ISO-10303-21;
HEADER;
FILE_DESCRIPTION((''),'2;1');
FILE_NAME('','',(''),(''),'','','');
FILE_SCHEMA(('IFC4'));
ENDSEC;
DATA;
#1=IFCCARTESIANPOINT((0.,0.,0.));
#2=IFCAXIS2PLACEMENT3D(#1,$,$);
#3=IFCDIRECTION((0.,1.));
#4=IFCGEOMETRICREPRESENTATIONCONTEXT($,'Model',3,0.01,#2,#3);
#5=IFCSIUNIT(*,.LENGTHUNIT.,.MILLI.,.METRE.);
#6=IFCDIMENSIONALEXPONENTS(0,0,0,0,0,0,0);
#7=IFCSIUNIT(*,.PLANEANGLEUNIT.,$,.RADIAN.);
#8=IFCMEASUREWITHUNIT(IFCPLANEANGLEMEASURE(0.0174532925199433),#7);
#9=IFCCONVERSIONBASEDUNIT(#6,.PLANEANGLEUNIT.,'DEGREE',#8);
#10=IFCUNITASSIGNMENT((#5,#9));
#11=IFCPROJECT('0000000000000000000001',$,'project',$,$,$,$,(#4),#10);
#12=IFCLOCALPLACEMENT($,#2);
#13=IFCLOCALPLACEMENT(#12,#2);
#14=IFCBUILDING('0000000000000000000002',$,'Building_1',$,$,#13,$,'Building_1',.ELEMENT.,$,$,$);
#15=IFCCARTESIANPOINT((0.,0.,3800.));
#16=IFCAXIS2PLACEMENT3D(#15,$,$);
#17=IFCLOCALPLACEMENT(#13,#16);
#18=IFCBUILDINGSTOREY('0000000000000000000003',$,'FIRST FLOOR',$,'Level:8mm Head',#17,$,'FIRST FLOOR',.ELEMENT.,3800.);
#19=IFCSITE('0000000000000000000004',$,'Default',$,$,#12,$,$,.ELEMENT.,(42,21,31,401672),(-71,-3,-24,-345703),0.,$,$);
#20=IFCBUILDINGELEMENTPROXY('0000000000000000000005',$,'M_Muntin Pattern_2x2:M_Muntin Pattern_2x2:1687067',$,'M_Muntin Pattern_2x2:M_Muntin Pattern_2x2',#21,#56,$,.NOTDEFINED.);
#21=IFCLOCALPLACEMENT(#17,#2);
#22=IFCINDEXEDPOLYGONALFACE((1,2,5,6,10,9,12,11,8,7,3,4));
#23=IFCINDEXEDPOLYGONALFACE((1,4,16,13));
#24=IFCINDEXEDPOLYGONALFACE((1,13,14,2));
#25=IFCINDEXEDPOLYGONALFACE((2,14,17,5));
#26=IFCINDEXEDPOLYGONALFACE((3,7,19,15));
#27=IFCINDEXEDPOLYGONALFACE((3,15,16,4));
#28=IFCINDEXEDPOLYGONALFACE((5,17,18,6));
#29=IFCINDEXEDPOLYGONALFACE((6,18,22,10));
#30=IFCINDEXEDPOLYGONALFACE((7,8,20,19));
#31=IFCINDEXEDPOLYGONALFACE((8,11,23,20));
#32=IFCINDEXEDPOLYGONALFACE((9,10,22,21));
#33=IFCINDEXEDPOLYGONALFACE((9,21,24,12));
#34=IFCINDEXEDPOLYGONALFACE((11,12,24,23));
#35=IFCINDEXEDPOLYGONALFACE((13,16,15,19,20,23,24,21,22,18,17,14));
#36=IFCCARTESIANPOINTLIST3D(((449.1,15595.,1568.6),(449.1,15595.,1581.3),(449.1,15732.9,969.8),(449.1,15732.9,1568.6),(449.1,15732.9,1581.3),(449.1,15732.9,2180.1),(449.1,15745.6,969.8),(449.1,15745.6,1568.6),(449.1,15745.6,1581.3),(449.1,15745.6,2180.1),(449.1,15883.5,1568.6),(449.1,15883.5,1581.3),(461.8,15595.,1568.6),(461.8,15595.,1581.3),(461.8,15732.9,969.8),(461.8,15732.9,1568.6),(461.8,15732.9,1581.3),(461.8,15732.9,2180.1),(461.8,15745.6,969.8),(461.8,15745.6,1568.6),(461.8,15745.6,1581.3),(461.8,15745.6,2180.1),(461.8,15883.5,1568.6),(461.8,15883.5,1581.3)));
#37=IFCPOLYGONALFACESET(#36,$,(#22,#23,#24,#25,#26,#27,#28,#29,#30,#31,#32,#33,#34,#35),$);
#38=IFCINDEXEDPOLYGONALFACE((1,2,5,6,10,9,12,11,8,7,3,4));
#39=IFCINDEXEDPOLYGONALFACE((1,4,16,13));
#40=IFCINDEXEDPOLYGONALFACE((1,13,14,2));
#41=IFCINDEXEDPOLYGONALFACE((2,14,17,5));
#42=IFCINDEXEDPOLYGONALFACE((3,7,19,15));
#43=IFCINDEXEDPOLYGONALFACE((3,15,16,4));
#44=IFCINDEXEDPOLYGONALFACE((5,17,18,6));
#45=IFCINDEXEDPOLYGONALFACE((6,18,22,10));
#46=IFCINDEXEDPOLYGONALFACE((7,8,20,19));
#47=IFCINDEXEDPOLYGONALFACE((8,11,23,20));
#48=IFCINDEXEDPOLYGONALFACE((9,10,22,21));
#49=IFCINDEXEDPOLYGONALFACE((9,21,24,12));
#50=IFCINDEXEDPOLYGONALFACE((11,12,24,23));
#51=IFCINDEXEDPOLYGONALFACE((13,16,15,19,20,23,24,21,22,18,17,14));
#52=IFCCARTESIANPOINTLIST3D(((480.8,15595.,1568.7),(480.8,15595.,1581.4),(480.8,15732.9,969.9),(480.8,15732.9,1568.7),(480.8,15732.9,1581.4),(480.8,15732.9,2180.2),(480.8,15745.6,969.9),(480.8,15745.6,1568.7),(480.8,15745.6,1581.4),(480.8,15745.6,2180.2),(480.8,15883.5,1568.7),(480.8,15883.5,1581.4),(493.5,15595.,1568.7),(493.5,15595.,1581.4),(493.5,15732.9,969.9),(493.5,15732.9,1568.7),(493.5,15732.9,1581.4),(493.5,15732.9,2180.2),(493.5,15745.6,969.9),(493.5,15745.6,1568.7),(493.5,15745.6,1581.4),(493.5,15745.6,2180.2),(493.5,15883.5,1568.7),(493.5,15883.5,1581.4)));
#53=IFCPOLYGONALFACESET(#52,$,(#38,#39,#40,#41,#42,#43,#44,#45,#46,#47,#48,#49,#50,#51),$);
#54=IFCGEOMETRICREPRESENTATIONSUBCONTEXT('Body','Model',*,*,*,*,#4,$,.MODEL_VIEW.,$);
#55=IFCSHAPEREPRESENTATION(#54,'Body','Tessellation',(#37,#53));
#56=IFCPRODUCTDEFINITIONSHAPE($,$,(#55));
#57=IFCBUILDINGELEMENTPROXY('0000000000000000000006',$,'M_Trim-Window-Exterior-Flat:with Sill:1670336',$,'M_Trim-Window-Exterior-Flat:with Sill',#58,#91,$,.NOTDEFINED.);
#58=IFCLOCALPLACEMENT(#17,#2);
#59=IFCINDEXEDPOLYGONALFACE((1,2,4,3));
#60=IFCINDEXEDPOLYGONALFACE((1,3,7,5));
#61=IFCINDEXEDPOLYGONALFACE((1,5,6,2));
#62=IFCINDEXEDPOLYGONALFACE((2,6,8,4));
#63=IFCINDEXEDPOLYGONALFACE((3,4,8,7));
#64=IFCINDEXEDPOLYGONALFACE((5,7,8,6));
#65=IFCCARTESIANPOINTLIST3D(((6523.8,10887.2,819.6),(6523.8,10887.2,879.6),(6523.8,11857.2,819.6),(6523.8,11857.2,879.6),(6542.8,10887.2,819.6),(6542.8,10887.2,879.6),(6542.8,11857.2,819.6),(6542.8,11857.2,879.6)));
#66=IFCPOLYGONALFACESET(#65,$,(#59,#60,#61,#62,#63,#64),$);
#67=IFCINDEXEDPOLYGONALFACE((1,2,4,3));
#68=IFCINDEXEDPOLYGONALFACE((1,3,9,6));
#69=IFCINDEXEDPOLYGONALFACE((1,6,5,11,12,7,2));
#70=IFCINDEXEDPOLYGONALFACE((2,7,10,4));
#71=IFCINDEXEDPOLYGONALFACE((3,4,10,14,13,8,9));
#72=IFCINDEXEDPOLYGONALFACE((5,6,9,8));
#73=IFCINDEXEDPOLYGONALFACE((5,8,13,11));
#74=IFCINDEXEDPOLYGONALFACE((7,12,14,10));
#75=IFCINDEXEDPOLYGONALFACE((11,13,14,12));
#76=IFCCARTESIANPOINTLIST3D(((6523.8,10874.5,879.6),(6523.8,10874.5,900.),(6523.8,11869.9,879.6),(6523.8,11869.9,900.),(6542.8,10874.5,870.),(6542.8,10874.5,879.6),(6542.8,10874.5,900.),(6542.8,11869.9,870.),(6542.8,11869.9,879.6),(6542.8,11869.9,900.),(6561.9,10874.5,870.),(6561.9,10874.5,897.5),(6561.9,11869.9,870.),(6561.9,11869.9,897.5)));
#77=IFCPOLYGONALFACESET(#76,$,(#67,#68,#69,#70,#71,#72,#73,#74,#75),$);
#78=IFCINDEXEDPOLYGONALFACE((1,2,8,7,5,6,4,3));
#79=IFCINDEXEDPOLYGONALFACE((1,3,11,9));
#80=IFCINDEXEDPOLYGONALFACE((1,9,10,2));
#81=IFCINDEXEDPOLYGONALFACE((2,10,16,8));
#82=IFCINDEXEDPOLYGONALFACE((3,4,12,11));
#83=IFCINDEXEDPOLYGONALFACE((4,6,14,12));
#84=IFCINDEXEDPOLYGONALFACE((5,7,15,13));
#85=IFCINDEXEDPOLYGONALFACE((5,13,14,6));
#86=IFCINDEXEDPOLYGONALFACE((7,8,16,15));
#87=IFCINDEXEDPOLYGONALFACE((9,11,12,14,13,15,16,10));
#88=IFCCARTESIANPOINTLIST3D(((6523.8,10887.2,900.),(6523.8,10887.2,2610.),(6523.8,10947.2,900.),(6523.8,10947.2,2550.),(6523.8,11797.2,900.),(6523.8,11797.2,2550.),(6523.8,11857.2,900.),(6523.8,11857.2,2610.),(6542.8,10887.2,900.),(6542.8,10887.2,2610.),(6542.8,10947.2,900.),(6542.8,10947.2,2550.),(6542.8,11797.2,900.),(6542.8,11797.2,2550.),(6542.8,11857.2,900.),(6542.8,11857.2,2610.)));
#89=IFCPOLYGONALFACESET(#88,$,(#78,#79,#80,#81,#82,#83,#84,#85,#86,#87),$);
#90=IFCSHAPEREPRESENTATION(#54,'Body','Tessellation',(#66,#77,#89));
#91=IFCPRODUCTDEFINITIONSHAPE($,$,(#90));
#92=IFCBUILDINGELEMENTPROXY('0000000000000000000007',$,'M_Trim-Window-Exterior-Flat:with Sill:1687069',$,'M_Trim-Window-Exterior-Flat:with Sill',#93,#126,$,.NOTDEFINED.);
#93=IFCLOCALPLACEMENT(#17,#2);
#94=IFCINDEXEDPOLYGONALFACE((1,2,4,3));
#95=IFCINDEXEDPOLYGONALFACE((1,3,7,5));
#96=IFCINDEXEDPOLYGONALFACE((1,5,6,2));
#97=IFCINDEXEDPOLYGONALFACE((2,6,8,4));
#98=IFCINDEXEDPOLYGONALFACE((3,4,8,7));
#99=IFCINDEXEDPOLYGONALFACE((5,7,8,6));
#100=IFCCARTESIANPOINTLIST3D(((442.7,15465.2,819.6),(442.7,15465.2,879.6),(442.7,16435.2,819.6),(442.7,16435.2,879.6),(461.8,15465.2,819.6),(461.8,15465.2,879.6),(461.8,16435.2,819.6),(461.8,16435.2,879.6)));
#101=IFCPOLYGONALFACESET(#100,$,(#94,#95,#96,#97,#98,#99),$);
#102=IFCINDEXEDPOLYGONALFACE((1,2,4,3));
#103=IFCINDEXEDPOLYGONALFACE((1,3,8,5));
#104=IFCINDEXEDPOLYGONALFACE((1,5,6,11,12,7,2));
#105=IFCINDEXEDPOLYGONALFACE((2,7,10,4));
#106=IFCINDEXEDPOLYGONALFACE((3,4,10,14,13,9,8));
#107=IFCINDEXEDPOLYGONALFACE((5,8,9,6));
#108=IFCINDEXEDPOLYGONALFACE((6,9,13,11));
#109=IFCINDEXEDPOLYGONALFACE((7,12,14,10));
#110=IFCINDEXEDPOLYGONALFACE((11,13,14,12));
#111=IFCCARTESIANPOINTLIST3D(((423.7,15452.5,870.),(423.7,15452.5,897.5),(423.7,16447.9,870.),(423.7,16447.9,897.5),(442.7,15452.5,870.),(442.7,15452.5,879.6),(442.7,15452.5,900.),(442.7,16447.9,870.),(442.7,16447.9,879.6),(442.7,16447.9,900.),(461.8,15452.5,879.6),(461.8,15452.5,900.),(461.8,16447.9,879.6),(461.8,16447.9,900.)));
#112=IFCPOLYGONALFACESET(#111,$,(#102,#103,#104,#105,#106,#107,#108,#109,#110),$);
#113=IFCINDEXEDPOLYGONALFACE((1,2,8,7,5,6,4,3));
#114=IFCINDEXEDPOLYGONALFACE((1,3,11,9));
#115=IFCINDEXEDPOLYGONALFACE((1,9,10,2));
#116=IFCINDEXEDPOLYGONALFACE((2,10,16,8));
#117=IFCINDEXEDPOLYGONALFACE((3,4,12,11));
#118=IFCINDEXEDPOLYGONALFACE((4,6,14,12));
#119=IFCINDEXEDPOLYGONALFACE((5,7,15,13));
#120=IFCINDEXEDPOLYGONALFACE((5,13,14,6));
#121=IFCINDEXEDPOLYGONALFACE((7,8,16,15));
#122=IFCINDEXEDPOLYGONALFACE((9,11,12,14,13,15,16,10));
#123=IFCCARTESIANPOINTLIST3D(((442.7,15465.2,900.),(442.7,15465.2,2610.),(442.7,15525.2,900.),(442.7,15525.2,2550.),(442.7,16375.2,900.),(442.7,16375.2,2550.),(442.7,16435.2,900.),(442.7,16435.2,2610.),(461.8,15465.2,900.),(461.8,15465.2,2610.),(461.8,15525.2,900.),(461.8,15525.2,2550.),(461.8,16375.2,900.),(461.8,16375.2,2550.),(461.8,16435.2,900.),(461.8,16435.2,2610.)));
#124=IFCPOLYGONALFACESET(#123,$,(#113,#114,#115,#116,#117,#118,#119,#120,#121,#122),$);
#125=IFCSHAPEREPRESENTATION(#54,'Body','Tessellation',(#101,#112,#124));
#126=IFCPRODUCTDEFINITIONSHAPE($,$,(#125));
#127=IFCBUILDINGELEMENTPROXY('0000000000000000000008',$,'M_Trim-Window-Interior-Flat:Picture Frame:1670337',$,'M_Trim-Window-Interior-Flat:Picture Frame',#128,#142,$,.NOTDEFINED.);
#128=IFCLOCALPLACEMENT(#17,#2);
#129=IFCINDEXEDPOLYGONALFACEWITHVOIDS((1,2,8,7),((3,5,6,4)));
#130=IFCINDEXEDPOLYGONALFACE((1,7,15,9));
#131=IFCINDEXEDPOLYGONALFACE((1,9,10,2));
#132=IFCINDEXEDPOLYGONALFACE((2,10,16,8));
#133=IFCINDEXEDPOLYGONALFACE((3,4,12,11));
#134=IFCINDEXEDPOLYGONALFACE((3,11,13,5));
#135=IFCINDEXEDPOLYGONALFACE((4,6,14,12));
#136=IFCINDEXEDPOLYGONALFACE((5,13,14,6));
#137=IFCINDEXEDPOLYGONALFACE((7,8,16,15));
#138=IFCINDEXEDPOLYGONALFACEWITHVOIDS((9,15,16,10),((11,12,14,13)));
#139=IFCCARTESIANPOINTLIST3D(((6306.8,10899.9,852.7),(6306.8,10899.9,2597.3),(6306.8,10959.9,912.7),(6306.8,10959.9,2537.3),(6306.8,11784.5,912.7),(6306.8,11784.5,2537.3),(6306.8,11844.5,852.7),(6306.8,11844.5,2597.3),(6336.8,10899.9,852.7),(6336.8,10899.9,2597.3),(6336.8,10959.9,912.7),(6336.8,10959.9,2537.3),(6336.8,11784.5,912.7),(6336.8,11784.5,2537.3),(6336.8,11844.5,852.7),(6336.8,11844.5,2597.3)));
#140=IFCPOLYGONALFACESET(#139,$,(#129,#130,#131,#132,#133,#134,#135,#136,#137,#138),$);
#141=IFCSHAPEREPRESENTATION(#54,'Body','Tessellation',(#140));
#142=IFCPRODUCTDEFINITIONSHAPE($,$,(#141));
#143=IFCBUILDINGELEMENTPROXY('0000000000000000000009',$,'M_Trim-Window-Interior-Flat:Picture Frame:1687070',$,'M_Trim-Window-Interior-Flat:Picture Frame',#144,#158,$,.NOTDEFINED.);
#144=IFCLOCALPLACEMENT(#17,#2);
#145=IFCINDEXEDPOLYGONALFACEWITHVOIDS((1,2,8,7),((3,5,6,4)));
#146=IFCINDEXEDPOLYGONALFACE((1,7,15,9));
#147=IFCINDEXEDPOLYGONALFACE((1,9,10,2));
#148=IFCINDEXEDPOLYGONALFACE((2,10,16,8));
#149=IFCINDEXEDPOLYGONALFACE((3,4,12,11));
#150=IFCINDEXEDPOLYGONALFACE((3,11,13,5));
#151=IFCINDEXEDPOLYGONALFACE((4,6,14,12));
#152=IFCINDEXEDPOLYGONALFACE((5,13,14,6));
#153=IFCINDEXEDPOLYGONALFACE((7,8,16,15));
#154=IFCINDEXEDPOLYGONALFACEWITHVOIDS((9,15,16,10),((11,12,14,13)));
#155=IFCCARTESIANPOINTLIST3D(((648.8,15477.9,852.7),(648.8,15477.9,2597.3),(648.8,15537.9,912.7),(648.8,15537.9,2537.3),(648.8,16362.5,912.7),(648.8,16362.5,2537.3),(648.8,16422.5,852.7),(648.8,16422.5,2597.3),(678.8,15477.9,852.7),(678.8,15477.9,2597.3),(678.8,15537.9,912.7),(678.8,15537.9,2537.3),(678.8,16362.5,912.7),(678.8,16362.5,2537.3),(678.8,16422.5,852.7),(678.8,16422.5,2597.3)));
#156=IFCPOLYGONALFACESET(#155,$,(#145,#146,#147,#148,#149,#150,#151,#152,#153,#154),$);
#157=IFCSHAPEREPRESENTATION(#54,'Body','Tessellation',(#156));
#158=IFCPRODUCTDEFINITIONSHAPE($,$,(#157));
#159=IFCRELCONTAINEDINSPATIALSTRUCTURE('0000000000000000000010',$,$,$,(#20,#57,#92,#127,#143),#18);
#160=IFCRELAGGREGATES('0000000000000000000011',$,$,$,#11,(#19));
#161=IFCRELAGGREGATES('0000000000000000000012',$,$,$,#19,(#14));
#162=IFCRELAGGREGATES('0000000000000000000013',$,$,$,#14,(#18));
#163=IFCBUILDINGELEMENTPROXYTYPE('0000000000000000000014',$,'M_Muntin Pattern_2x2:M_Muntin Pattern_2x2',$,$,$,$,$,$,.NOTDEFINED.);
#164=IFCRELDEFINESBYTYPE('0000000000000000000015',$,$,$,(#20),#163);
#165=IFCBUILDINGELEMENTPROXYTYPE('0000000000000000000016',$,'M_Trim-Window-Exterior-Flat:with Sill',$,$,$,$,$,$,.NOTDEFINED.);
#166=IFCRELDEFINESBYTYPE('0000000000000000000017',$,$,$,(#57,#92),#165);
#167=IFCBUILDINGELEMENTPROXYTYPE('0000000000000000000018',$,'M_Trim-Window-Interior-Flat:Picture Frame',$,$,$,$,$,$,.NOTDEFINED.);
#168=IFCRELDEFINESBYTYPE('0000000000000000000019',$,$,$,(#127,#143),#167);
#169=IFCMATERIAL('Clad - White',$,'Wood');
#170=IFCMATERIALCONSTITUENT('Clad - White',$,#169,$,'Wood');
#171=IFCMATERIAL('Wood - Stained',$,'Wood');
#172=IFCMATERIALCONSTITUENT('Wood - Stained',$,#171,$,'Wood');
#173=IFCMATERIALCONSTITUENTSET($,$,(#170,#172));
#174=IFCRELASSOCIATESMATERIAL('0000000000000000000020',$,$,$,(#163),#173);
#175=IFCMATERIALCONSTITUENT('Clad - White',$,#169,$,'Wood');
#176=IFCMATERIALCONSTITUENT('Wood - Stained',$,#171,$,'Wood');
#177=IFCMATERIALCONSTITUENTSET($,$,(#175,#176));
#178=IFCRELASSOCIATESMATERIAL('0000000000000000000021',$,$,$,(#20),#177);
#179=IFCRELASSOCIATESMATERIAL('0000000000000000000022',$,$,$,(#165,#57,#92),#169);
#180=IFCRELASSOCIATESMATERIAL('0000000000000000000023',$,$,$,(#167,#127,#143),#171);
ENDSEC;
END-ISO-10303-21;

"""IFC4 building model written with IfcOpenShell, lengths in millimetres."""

from ifc_helpers import new_model, entity, si_unit, converted_unit, direction, frame, origin, place, context, subcontext, project, spatial, indexed_curve, outline, extrude, source, transform, mapped, material, constituent, constituent_set, type_object, type_shapes, element, save


model = new_model("IFC4")

# Units and contexts
model_context = context("Model", 3, precision=0.01, world=origin(), true_north=direction((0.0, 1.0)))
body_context = subcontext(model_context, "Body", "Model", "MODEL_VIEW")
ifc_project = project(units=[si_unit("LENGTHUNIT", "METRE", prefix="MILLI"), converted_unit("PLANEANGLEUNIT", "DEGREE", entity("IfcPlaneAngleMeasure", 0.0174532925199433), si_unit("PLANEANGLEUNIT", "RADIAN"), dimensions=[0, 0, 0, 0, 0, 0, 0])], contexts=[model_context])

# Site, building, storey
site_placement = place(None, origin())
site = spatial("IfcSite", under=ifc_project, at=site_placement, Name="Default", CompositionType="ELEMENT", RefLatitude=(42, 21, 31, 401672), RefLongitude=(-71, -3, -24, -345703), RefElevation=0.0)
building_placement = place(site_placement, origin())
building = spatial("IfcBuilding", under=site, at=building_placement, Name="Building_1", LongName="Building_1", CompositionType="ELEMENT")
storey_placement = place(building_placement, frame((0.0, 0.0, 3800.0)))
storey = spatial("IfcBuildingStorey", under=building, at=storey_placement, Name="FIRST FLOOR", ObjectType="Level:8mm Head", LongName="FIRST FLOOR", CompositionType="ELEMENT", Elevation=3800.0)

# Shared definitions
ifc_material_1 = material(Name="Wood - Stained", Category="Wood")

# Building element proxies
ifc_material_2 = material(Name="Clad - White", Category="Wood")
ifc_constituent_1 = constituent(ifc_material_2, Name="Clad - White", Category="Wood")
ifc_constituent_2 = constituent(ifc_material_1, Name="Wood - Stained", Category="Wood")
ifc_constituent_set_1 = constituent_set(constituents=[ifc_constituent_1, ifc_constituent_2])
building_element_proxy_type_1 = type_object("IfcBuildingElementProxyType", Name="M_Muntin Pattern_2x2:M_Muntin Pattern_2x2", PredefinedType="NOTDEFINED", material=ifc_constituent_set_1)
shared_shape_1 = source(origin(), body_context, "Body", "SweptSolid", [
    extrude(outline(indexed_curve([(6.4, -6.4), (605.1, -6.4), (605.1, 6.3), (6.4, 6.3), (6.4, 144.2), (-6.3, 144.2), (-6.3, 6.3), (-605.2, 6.3), (-605.2, -6.4), (-6.3, -6.4), (-6.3, -144.2), (6.4, -144.2), (6.4, -6.4)], self_intersect=False)), frame((0.0, 9.5, 605.1), z_axis=(0.0, 1.0, 0.0), x_axis=(0.0, 0.0, 1.0)), (0.0, 0.0, 1.0), 12.7),
    extrude(outline(indexed_curve([(6.4, -6.4), (605.2, -6.4), (605.2, 6.3), (6.4, 6.3), (6.4, 144.2), (-6.3, 144.2), (-6.3, 6.3), (-605.2, 6.3), (-605.2, -6.4), (-6.3, -6.4), (-6.3, -144.2), (6.4, -144.2), (6.4, -6.4)], self_intersect=False)), frame((0.0, -22.2, 605.2), z_axis=(0.0, 1.0, 0.0), x_axis=(0.0, 0.0, 1.0)), (0.0, 0.0, 1.0), 12.7),
])
type_shapes(building_element_proxy_type_1, [shared_shape_1])
ifc_constituent_3 = constituent(ifc_material_2, Name="Clad - White", Category="Wood")
ifc_constituent_4 = constituent(ifc_material_1, Name="Wood - Stained", Category="Wood")
ifc_constituent_set_2 = constituent_set(constituents=[ifc_constituent_3, ifc_constituent_4])
proxy_1_placement = place(storey_placement, frame((471.3, 15739.3, 969.9), z_axis=(0.0, 0.0, 1.0), x_axis=(0.0, 1.0, 0.0)))
element("IfcBuildingElementProxy", 1, at=proxy_1_placement, inside=storey, type_object=building_element_proxy_type_1, material=ifc_constituent_set_2, Name="M_Muntin Pattern_2x2:M_Muntin Pattern_2x2:1687067", ObjectType="M_Muntin Pattern_2x2:M_Muntin Pattern_2x2", PredefinedType="NOTDEFINED", context=body_context, shape_type="MappedRepresentation", body=[
    mapped(shared_shape_1, transform((0.0, 0.0, 0.0), scale=1.0)),
])
building_element_proxy_type_2 = type_object("IfcBuildingElementProxyType", Name="M_Trim-Window-Exterior-Flat:with Sill", PredefinedType="NOTDEFINED", material=ifc_material_2)
shared_shape_2 = source(origin(), body_context, "Body", "SweptSolid", [
    extrude(outline(indexed_curve([(-485.0, -30.0), (485.0, -30.0), (485.0, 30.0), (-485.0, 30.0), (-485.0, -30.0)], self_intersect=False)), frame((0.0, -1700.4, 0.0), z_axis=(0.0, 0.0, 1.0), x_axis=(-1.0, 0.0, 0.0)), (0.0, 0.0, 1.0), 19.1),
    extrude(outline(indexed_curve([(-19.0, -15.2), (0.0, -15.2), (0.0, -5.7), (19.0, -5.7), (19.0, 14.8), (0.0, 14.8), (-19.0, 12.3), (-19.0, -15.2)], self_intersect=False)), frame((-497.7, -1664.8, 19.0), z_axis=(1.0, 0.0, 0.0), x_axis=(0.0, 0.0, -1.0)), (0.0, 0.0, 1.0), 995.4),
    extrude(outline(indexed_curve([(-870.0, -485.0), (840.0, -485.0), (840.0, -425.0), (-810.0, -425.0), (-810.0, 425.0), (840.0, 425.0), (840.0, 485.0), (-870.0, 485.0), (-870.0, -485.0)], self_intersect=False)), frame((0.0, -810.0, 0.0), z_axis=(0.0, 0.0, 1.0), x_axis=(0.0, -1.0, 0.0)), (0.0, 0.0, 1.0), 19.1),
])
type_shapes(building_element_proxy_type_2, [shared_shape_2])
for number, where, z_axis, x_axis, name in (
    (2, (6523.8, 11372.2, 2550.0), (1.0, 0.0, 0.0), (0.0, 1.0, 0.0), "M_Trim-Window-Exterior-Flat:with Sill:1670336"),
    (3, (461.8, 15950.2, 2550.0), (-1.0, 0.0, 0.0), (0.0, -1.0, 0.0), "M_Trim-Window-Exterior-Flat:with Sill:1687069"),
):
    element("IfcBuildingElementProxy", number, at=place(storey_placement, frame(where, z_axis=z_axis, x_axis=x_axis)), inside=storey, type_object=building_element_proxy_type_2, material=ifc_material_2, Name=name, ObjectType="M_Trim-Window-Exterior-Flat:with Sill", PredefinedType="NOTDEFINED", context=body_context, shape_type="MappedRepresentation", body=[
        mapped(shared_shape_2, transform((0.0, 0.0, 0.0), scale=1.0)),
    ])
building_element_proxy_type_3 = type_object("IfcBuildingElementProxyType", Name="M_Trim-Window-Interior-Flat:Picture Frame", PredefinedType="NOTDEFINED", material=ifc_material_1)
shared_shape_3 = source(origin(), body_context, "Body", "SweptSolid", [
    extrude(outline(indexed_curve([(-472.3, -872.3), (472.3, -872.3), (472.3, 872.3), (-472.3, 872.3), (-472.3, -872.3)], self_intersect=False), holes=[indexed_curve([(-412.3, -812.3), (-412.3, 812.3), (412.3, 812.3), (412.3, -812.3), (-412.3, -812.3)], self_intersect=False)]), frame((0.0, -825.0, 0.0), z_axis=(0.0, 0.0, 1.0), x_axis=(-1.0, 0.0, 0.0)), (0.0, 0.0, 1.0), 30.0),
])
type_shapes(building_element_proxy_type_3, [shared_shape_3])
for number, where, z_axis, x_axis, name in (
    (4, (6336.8, 11372.2, 2550.0), (-1.0, 0.0, 0.0), (0.0, -1.0, 0.0), "M_Trim-Window-Interior-Flat:Picture Frame:1670337"),
    (5, (648.8, 15950.2, 2550.0), (1.0, 0.0, 0.0), (0.0, 1.0, 0.0), "M_Trim-Window-Interior-Flat:Picture Frame:1687070"),
):
    element("IfcBuildingElementProxy", number, at=place(storey_placement, frame(where, z_axis=z_axis, x_axis=x_axis)), inside=storey, type_object=building_element_proxy_type_3, material=ifc_material_1, Name=name, ObjectType="M_Trim-Window-Interior-Flat:Picture Frame", PredefinedType="NOTDEFINED", context=body_context, shape_type="MappedRepresentation", body=[
        mapped(shared_shape_3, transform((0.0, 0.0, 0.0), scale=1.0)),
    ])

save(model, "model.ifc")
